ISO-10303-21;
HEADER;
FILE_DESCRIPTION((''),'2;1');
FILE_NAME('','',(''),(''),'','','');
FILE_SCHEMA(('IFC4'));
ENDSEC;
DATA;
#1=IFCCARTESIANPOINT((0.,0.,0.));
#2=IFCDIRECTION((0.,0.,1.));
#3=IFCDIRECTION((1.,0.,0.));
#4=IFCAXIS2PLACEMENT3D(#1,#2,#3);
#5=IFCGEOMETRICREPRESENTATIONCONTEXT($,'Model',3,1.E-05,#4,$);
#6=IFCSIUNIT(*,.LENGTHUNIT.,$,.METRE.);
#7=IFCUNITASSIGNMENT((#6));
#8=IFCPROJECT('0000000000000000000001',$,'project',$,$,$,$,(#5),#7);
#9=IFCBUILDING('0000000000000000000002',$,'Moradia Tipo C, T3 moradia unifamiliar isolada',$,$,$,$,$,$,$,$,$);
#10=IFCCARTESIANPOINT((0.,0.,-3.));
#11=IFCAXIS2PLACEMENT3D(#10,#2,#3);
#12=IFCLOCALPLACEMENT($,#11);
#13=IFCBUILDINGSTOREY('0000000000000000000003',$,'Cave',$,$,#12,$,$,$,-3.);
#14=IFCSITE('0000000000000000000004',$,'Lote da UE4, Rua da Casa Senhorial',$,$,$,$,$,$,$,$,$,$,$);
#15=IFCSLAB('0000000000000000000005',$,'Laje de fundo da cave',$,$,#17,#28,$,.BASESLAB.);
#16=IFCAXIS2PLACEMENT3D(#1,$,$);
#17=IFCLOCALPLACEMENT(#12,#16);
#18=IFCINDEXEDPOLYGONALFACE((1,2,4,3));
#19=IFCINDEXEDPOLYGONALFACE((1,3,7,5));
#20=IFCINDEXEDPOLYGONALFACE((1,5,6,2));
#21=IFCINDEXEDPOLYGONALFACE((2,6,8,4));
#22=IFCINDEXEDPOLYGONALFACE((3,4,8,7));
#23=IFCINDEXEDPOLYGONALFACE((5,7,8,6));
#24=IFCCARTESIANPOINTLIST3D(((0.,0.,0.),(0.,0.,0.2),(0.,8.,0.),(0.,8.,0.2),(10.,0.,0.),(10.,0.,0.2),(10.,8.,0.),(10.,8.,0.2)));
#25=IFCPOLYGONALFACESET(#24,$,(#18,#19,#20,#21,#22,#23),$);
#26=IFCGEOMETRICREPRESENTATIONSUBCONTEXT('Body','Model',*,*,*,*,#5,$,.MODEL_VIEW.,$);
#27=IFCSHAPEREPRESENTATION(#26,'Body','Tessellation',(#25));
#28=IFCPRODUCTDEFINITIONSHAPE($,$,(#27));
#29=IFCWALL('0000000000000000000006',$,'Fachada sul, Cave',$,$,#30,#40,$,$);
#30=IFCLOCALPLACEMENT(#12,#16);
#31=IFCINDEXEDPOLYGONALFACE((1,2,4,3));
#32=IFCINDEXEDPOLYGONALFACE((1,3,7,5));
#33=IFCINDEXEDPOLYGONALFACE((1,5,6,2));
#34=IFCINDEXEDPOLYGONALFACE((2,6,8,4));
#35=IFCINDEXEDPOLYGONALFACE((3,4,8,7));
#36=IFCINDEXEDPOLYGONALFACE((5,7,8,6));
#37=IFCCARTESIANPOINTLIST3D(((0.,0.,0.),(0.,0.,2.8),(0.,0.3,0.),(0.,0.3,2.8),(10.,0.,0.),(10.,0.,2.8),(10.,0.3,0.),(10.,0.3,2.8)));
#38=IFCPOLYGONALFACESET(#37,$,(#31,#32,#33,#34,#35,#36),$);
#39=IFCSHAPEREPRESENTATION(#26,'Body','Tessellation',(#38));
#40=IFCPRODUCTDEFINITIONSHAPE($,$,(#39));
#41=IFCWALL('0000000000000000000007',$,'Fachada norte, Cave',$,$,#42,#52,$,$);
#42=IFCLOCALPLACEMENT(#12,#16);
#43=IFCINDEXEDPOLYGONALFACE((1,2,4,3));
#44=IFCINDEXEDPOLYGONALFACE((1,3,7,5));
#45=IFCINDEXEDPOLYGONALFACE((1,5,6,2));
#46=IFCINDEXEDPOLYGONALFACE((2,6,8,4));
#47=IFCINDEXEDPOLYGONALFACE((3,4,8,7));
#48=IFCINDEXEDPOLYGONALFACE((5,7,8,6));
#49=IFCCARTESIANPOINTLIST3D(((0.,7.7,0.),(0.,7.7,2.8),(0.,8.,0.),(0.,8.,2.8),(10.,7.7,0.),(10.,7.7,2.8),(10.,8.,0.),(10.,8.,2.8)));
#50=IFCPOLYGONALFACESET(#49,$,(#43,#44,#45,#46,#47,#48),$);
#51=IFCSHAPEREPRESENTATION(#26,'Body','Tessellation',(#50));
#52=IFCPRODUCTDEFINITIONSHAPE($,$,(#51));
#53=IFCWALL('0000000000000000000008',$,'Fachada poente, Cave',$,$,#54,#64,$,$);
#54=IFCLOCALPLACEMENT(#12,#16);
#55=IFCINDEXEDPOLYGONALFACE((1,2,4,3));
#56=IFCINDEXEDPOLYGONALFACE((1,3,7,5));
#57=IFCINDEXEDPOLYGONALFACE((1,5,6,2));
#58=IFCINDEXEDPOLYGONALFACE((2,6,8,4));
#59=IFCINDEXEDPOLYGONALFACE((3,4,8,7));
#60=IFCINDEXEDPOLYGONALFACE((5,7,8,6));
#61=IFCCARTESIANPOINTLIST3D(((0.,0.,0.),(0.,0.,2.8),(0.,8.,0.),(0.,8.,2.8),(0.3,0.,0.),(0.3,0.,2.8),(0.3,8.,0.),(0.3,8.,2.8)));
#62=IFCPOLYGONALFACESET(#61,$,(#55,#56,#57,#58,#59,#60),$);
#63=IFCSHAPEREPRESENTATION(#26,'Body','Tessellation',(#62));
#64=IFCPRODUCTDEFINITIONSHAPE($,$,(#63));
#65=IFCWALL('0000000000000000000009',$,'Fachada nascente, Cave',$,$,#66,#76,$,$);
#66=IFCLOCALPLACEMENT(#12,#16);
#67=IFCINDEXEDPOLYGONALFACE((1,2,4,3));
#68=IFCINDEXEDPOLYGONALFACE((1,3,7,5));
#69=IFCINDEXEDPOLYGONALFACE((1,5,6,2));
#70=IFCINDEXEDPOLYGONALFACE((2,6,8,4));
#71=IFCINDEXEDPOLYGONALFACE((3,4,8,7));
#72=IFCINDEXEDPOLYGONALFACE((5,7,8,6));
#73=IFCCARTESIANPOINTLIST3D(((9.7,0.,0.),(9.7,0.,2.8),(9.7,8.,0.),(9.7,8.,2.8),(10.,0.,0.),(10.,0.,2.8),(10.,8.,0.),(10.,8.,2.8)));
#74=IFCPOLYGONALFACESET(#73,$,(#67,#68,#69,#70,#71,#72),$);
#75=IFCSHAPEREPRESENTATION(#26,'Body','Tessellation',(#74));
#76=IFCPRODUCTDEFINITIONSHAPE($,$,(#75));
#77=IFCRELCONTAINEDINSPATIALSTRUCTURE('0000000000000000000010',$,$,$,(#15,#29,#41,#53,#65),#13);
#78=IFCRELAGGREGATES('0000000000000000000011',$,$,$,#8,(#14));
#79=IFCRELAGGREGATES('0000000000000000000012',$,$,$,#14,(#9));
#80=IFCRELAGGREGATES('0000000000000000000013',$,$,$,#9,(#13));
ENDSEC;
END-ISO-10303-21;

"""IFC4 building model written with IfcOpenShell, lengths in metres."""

from ifc_helpers import new_model, si_unit, frame, origin_with_axes, place, context, subcontext, project, spatial, indexed_curve, outline, extrude, element, save


model = new_model("IFC4")

# Units and contexts
model_context = context("Model", 3, precision=1e-05, world=origin_with_axes())
body_context = subcontext(model_context, "Body", "Model", "MODEL_VIEW")
ifc_project = project(units=[si_unit("LENGTHUNIT", "METRE")], contexts=[model_context])

# Site, building, storey
site = spatial("IfcSite", under=ifc_project, Name="Lote da UE4, Rua da Casa Senhorial")
building = spatial("IfcBuilding", under=site, Name="Moradia Tipo C, T3 moradia unifamiliar isolada")
storey_placement = place(None, frame((0.0, 0.0, -3.0), z_axis=(0.0, 0.0, 1.0), x_axis=(1.0, 0.0, 0.0)))
storey = spatial("IfcBuildingStorey", under=building, at=storey_placement, Name="Cave", Elevation=-3.0)

# Slab
slab_placement = place(storey_placement, origin_with_axes())
element("IfcSlab", 1, at=slab_placement, inside=storey, Name="Laje de fundo da cave", PredefinedType="BASESLAB", context=body_context, shape_type="SweptSolid", body=[
    extrude(outline(indexed_curve([(0.0, 0.0), (10.0, 0.0), (10.0, 8.0), (0.0, 8.0), (0.0, 0.0)])), None, (0.0, 0.0, 1.0), 0.2),
])

# Walls
for number, where, z_axis, x_axis, name in (
    (2, (0.0, 0.0, 0.0), (0.0, 0.0, 1.0), (1.0, 0.0, 0.0), "Fachada sul, Cave"),
    (3, (0.0, 7.7, 0.0), (0.0, 0.0, 1.0), (1.0, 0.0, 0.0), "Fachada norte, Cave"),
):
    element("IfcWall", number, at=place(storey_placement, frame(where, z_axis=z_axis, x_axis=x_axis)), inside=storey, Name=name, context=body_context, shape_type="SweptSolid", body=[
        extrude(outline(indexed_curve([(0.0, 0.0), (0.0, 0.3), (10.0, 0.3), (10.0, 0.0), (0.0, 0.0)], self_intersect=False)), origin_with_axes(), (0.0, 0.0, 1.0), 2.8),
    ])
for number, where, z_axis, x_axis, name in (
    (4, (0.3, 0.0, 0.0), (0.0, 0.0, 1.0), (0.0, 1.0, 0.0), "Fachada poente, Cave"),
    (5, (10.0, 0.0, 0.0), (0.0, 0.0, 1.0), (0.0, 1.0, 0.0), "Fachada nascente, Cave"),
):
    element("IfcWall", number, at=place(storey_placement, frame(where, z_axis=z_axis, x_axis=x_axis)), inside=storey, Name=name, context=body_context, shape_type="SweptSolid", body=[
        extrude(outline(indexed_curve([(0.0, 0.0), (0.0, 0.3), (8.0, 0.3), (8.0, 0.0), (0.0, 0.0)], self_intersect=False)), origin_with_axes(), (0.0, 0.0, 1.0), 2.8),
    ])

save(model, "model.ifc")
